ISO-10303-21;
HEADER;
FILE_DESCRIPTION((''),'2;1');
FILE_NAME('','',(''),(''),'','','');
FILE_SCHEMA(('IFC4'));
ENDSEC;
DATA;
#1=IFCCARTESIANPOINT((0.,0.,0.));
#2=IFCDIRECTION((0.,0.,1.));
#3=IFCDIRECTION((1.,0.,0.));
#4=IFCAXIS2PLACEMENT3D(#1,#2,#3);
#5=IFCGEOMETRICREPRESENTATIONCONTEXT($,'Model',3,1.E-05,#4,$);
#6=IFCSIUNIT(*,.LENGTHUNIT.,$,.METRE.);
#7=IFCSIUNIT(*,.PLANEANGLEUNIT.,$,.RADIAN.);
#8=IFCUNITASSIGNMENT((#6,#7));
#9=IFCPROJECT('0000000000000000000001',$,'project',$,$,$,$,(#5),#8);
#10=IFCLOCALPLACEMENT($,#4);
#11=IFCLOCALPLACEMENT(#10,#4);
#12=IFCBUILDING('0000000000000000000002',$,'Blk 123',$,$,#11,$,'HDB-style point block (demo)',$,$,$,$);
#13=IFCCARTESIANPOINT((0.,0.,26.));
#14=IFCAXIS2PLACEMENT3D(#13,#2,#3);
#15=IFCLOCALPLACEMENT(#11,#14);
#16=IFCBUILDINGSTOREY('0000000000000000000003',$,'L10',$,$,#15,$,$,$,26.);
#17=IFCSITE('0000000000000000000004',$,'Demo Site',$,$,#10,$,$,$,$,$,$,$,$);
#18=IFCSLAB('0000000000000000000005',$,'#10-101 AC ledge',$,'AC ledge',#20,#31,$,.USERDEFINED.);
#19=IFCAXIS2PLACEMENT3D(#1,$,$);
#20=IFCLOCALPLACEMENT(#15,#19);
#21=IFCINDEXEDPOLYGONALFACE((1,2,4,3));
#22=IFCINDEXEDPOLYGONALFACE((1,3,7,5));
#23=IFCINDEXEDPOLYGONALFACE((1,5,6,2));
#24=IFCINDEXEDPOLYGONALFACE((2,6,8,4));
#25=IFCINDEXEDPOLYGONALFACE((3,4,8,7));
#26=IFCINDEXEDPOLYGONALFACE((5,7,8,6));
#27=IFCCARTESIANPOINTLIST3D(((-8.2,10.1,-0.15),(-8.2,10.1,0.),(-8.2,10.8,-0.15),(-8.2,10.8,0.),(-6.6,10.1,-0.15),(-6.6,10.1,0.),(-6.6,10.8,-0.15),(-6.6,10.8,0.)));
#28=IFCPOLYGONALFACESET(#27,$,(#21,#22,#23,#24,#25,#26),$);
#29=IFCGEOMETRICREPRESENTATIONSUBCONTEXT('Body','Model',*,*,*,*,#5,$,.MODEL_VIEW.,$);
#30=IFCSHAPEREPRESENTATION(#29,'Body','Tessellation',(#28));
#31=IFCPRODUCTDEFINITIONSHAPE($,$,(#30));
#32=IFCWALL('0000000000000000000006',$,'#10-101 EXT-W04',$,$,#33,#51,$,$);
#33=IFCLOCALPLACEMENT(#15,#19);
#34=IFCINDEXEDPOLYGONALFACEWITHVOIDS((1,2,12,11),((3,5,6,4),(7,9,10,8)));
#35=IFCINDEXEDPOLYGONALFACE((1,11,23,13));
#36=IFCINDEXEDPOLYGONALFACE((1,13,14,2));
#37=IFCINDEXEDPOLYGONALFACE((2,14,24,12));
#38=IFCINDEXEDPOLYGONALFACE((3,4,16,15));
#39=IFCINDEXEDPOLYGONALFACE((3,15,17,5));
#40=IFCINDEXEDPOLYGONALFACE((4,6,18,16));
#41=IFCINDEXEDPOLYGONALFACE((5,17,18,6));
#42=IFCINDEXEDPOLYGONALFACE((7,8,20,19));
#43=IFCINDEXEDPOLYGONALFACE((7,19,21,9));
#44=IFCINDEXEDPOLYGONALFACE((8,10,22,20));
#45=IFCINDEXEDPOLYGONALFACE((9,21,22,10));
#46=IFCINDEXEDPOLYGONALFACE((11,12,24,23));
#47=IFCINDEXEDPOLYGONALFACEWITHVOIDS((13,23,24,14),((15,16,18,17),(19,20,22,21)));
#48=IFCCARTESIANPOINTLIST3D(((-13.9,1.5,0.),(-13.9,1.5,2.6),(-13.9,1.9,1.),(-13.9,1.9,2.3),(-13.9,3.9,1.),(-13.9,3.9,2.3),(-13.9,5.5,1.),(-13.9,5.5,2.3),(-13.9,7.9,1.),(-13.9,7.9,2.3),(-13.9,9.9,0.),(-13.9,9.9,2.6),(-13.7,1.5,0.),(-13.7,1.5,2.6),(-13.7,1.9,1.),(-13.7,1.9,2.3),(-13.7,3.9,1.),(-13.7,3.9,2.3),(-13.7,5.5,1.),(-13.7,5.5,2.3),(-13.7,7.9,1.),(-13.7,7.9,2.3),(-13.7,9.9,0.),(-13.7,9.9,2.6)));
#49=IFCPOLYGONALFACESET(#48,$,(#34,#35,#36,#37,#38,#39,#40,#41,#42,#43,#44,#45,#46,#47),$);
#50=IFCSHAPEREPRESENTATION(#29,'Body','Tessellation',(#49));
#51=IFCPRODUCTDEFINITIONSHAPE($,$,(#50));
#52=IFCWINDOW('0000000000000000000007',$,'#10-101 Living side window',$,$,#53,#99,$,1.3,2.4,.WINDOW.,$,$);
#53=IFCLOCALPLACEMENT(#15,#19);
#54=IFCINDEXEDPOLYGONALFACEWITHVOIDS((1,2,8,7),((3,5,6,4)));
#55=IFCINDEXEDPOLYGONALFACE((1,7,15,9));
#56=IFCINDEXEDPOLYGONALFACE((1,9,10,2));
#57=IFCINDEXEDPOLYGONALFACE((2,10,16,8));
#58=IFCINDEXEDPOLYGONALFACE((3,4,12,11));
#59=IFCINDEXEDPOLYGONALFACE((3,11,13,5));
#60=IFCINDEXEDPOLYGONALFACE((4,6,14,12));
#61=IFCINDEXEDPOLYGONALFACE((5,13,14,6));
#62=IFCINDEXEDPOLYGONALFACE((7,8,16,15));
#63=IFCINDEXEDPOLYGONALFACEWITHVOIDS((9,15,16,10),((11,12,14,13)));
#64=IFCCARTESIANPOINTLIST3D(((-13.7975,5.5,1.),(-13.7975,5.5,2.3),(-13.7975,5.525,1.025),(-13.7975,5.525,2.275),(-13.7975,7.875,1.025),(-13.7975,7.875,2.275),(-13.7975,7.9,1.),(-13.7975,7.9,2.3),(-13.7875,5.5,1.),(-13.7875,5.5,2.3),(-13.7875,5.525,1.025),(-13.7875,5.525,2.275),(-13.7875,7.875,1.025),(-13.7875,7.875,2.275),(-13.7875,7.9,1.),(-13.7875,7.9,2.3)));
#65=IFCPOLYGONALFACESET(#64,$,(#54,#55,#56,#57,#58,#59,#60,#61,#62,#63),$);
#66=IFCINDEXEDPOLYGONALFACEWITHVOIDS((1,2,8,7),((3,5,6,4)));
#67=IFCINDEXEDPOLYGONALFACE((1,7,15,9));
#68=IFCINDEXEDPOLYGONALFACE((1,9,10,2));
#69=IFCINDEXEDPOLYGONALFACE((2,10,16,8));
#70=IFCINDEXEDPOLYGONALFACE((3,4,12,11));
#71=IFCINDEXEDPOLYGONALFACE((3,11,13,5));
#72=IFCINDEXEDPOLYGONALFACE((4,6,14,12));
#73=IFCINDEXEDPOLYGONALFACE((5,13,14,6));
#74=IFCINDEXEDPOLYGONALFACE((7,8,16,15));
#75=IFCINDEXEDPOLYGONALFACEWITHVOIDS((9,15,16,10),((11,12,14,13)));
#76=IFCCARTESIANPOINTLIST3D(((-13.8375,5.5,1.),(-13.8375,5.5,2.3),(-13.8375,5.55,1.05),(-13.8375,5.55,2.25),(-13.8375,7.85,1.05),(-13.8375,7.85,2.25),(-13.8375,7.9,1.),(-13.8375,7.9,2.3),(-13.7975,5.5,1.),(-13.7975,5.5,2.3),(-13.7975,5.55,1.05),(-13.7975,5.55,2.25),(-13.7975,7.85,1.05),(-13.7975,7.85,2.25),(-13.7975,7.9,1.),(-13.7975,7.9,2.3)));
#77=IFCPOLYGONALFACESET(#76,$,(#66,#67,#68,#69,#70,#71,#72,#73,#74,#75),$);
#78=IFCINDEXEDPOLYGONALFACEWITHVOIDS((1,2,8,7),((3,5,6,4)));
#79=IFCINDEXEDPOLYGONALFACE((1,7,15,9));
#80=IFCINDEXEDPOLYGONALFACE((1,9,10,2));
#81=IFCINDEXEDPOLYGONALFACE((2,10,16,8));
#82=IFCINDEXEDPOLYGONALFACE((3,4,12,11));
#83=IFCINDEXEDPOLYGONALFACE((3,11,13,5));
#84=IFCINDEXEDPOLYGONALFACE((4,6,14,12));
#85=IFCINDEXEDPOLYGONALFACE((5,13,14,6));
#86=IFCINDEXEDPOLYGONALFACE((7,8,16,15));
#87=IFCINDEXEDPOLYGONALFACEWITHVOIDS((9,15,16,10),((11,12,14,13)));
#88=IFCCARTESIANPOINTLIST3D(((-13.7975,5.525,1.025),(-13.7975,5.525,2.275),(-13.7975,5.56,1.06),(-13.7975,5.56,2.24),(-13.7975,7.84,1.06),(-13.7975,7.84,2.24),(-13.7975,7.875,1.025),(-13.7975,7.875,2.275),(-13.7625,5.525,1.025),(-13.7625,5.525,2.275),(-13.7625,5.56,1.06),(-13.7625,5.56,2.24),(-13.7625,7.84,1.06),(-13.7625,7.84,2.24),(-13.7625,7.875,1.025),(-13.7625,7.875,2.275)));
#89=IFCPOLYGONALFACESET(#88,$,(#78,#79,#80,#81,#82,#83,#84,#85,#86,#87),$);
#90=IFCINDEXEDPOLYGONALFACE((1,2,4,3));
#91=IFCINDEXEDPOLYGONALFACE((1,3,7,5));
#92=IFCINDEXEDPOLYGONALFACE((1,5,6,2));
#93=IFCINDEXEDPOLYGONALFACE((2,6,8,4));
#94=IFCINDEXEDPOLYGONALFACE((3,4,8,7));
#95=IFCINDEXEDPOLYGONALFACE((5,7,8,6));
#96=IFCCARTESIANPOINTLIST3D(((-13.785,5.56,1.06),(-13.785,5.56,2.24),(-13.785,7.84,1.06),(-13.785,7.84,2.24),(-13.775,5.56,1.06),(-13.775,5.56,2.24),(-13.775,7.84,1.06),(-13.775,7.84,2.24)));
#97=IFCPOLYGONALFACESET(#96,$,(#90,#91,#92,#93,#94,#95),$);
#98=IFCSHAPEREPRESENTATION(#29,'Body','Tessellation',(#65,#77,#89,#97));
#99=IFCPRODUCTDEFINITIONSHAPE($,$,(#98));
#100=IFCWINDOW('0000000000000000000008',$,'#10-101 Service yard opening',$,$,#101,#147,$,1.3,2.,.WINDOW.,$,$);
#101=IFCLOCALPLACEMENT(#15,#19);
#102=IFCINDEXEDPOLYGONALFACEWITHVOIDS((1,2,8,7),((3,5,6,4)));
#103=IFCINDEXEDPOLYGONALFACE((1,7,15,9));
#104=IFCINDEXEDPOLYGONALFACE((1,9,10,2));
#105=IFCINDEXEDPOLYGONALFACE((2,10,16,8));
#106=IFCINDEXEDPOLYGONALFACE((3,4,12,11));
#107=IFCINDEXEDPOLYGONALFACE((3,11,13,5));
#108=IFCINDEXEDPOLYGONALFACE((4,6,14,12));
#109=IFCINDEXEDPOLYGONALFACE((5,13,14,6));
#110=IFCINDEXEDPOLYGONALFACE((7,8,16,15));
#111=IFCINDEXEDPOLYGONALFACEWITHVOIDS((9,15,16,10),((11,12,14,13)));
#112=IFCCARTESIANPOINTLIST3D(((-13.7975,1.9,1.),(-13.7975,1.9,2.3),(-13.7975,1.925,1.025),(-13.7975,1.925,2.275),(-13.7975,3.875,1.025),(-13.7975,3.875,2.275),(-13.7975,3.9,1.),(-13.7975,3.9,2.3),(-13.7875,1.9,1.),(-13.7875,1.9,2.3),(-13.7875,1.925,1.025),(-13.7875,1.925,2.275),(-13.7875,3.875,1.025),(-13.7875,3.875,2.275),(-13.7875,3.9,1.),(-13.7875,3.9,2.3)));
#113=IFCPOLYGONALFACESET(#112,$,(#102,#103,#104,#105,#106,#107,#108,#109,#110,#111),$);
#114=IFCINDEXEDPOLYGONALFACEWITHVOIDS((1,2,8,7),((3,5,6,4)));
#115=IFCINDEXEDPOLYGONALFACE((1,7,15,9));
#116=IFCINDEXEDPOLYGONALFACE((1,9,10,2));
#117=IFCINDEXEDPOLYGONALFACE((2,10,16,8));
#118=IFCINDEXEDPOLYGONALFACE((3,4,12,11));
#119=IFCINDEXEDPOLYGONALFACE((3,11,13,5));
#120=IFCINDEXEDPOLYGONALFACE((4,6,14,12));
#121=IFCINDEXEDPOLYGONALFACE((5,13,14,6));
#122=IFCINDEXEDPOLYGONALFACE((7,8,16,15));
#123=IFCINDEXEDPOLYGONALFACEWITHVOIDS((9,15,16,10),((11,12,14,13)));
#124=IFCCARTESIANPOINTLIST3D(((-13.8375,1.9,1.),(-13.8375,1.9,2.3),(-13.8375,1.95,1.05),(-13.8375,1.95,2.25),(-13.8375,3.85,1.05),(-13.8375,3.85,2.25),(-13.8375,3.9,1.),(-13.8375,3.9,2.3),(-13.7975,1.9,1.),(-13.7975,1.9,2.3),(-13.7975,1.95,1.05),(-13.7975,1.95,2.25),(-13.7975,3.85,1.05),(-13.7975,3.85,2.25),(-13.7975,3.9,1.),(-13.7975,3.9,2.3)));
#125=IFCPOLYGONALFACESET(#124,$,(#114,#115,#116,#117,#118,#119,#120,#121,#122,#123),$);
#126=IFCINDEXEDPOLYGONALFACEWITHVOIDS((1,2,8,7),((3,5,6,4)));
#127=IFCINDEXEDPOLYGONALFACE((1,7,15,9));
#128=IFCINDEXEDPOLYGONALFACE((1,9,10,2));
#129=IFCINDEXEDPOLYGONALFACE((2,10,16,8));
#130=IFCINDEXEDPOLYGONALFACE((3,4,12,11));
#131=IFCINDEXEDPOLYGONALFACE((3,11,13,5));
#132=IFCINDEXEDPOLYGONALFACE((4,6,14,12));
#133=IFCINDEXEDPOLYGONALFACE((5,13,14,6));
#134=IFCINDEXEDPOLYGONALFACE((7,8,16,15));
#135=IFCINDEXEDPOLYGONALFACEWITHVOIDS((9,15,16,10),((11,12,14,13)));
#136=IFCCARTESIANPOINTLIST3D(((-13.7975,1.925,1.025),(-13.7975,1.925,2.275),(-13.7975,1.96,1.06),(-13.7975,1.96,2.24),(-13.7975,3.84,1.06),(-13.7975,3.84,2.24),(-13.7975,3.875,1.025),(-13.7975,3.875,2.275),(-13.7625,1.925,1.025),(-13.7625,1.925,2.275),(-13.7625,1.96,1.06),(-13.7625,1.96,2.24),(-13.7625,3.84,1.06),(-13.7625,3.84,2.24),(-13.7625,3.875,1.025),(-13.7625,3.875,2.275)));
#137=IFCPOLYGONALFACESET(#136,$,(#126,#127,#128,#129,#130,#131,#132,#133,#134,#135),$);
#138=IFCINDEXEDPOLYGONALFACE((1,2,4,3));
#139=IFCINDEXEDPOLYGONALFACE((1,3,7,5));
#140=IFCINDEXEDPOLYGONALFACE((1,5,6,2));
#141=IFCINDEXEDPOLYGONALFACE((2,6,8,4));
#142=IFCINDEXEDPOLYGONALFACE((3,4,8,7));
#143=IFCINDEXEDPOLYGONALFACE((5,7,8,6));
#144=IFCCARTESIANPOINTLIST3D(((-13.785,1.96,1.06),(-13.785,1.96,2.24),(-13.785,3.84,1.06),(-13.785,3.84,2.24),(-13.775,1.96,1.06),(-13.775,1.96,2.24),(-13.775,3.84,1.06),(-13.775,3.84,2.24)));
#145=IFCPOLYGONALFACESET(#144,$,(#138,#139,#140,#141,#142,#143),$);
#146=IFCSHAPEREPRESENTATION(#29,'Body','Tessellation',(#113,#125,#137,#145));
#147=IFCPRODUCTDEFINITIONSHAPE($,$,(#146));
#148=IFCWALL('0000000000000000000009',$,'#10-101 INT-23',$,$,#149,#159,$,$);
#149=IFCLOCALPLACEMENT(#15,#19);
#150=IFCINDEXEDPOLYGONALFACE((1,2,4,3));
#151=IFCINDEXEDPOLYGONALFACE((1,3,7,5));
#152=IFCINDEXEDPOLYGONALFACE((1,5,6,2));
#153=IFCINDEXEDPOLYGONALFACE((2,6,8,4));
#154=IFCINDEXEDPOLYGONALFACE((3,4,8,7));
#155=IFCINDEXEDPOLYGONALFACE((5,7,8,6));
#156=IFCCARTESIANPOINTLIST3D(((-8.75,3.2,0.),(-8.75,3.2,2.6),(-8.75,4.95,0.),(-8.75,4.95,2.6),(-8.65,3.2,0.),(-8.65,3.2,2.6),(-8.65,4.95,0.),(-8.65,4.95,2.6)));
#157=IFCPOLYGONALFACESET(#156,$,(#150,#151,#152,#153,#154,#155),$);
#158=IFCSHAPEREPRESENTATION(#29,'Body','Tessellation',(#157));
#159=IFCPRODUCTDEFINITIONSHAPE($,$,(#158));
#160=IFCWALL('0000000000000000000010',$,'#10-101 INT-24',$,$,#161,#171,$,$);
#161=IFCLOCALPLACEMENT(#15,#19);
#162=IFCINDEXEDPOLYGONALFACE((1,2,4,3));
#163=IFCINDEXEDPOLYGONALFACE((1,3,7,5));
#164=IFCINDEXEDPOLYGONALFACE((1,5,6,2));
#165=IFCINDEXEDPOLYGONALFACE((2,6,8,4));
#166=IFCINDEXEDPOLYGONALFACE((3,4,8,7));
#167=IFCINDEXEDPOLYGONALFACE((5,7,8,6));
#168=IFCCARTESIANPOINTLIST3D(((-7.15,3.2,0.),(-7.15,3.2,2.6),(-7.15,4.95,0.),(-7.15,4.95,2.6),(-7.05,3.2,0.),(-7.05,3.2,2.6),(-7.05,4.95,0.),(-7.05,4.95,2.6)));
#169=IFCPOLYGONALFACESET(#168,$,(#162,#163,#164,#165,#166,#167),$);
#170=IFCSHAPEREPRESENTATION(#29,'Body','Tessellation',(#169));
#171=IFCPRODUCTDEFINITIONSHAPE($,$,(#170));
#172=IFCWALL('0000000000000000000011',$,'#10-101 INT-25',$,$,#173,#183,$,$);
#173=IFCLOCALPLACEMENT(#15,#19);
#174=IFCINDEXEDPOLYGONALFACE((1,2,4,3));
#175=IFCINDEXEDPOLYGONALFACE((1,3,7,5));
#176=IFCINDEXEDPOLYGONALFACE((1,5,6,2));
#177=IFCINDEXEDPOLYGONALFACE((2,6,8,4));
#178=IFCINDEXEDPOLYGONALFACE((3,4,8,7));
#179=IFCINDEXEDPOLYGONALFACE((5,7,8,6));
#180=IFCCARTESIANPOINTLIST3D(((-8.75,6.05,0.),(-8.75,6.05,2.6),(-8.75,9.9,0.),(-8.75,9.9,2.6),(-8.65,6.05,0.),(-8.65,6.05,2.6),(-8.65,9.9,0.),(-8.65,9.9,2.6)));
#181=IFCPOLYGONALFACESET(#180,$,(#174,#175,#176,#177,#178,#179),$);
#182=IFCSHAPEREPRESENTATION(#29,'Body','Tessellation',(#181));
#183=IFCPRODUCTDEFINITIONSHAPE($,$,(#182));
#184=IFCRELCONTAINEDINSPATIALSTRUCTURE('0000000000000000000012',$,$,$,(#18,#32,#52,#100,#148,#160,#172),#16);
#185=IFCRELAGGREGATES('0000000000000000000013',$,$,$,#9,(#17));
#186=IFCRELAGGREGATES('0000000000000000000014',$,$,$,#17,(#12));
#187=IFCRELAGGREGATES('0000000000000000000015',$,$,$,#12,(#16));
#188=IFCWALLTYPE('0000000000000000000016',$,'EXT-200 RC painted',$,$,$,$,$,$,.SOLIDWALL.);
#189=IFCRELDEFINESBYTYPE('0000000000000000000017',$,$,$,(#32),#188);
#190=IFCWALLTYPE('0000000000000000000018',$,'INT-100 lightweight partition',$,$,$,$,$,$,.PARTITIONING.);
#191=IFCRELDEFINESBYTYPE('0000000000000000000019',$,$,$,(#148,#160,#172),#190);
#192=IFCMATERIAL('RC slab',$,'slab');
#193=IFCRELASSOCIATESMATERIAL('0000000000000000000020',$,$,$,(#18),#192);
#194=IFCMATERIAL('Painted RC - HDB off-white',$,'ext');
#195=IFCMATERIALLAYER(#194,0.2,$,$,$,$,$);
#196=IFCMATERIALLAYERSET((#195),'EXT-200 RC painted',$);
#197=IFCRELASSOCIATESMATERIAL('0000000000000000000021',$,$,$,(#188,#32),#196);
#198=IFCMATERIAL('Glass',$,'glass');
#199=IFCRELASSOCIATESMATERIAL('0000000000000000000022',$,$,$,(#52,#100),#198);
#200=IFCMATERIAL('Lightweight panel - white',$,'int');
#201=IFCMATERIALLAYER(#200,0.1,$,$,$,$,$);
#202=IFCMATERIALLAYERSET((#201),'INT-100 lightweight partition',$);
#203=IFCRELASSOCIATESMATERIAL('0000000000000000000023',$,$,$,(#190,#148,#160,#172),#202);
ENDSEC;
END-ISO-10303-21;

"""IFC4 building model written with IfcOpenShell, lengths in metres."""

from ifc_helpers import new_model, si_unit, frame, origin, origin_with_axes, place, context, subcontext, project, spatial, polyline, line, indexed_curve, outline, extrude, material, layer, layer_set, layer_usage, type_object, element, fill, save


model = new_model("IFC4")

# Units and contexts
model_context = context("Model", 3, precision=1e-05, world=origin_with_axes())
body_context = subcontext(model_context, "Body", "Model", "MODEL_VIEW")
ifc_project = project(units=[si_unit("LENGTHUNIT", "METRE"), si_unit("PLANEANGLEUNIT", "RADIAN")], contexts=[model_context])

# Site, building, storey
site_placement = place(None, origin_with_axes())
site = spatial("IfcSite", under=ifc_project, at=site_placement, Name="Demo Site")
building_placement = place(site_placement, origin_with_axes())
building = spatial("IfcBuilding", under=site, at=building_placement, Name="Blk 123", LongName="HDB-style point block (demo)")
storey_placement = place(building_placement, frame((0.0, 0.0, 26.0), z_axis=(0.0, 0.0, 1.0), x_axis=(1.0, 0.0, 0.0)))
storey = spatial("IfcBuildingStorey", under=building, at=storey_placement, Name="L10", Elevation=26.0)

# Slab
ifc_material_1 = material(Name="RC slab", Category="slab")
slab_placement = place(storey_placement, frame((-7.4, 10.45, -0.15), z_axis=(0.0, 0.0, 1.0), x_axis=(1.0, 0.0, 0.0)))
element("IfcSlab", 1, at=slab_placement, inside=storey, material=ifc_material_1, Name="#10-101 AC ledge", ObjectType="AC ledge", PredefinedType="USERDEFINED", context=body_context, shape_type="SweptSolid", body=[
    extrude(outline(polyline([(-0.8, -0.35), (0.8, -0.35), (0.8, 0.35), (-0.8, 0.35), (-0.8, -0.35)])), origin(), (0.0, 0.0, 1.0), 0.15),
])

# Shared definitions
ifc_material_2 = material(Name="Painted RC - HDB off-white", Category="ext")
ifc_layer_1 = layer(ifc_material_2, 0.2)
ifc_layer_set_1 = layer_set([ifc_layer_1], Name="EXT-200 RC painted")
ifc_layer_usage_1 = layer_usage(ifc_layer_set_1, "AXIS2", "POSITIVE", 0.0)
wall_type_1 = type_object("IfcWallType", Name="EXT-200 RC painted", PredefinedType="SOLIDWALL", material=ifc_layer_set_1)
ifc_material_3 = material(Name="Glass", Category="glass")

# Wall, openings, windows
wall_1_placement = place(storey_placement, frame((-13.9, 9.9, 0.0), z_axis=(0.0, 0.0, 1.0), x_axis=(0.0, -1.0, 0.0)))
wall_1 = element("IfcWall", 2, at=wall_1_placement, inside=storey, type_object=wall_type_1, material=ifc_layer_usage_1, Name="#10-101 EXT-W04", context=body_context, shape_type="SweptSolid", body=[
    extrude(outline(indexed_curve([(0.0, 0.0), (0.0, 0.2), (8.4, 0.2), (8.4, 0.0), (0.0, 0.0)], self_intersect=False)), origin_with_axes(), (0.0, 0.0, 1.0), 2.6),
])
opening_1_placement = place(wall_1_placement, frame((2.0, -0.1, 1.0), z_axis=(0.0, 0.0, 1.0), x_axis=(1.0, 0.0, 0.0)))
opening_1 = element("IfcOpeningElement", 3, at=opening_1_placement, cuts=wall_1, context=body_context, shape_type="SweptSolid", body=[
    extrude(outline(indexed_curve([(0.0, 0.0), (0.0, 0.4), (2.4, 0.4), (2.4, 0.0), (0.0, 0.0)], self_intersect=False)), origin_with_axes(), (0.0, 0.0, 1.0), 1.3),
])
opening_2_placement = place(wall_1_placement, frame((6.0, -0.1, 1.0), z_axis=(0.0, 0.0, 1.0), x_axis=(1.0, 0.0, 0.0)))
opening_2 = element("IfcOpeningElement", 4, at=opening_2_placement, cuts=wall_1, context=body_context, shape_type="SweptSolid", body=[
    extrude(outline(indexed_curve([(0.0, 0.0), (0.0, 0.4), (2.0, 0.4), (2.0, 0.0), (0.0, 0.0)], self_intersect=False)), origin_with_axes(), (0.0, 0.0, 1.0), 1.3),
])
window_1_placement = place(opening_1_placement, frame((0.0, 0.1125, 0.0), z_axis=(0.0, 0.0, 1.0), x_axis=(1.0, 0.0, 0.0)))
window_1 = element("IfcWindow", 5, at=window_1_placement, inside=storey, material=ifc_material_3, Name="#10-101 Living side window", OverallHeight=1.3, OverallWidth=2.4, PredefinedType="WINDOW", context=body_context, shape_type="SweptSolid", body=[
    extrude(outline(indexed_curve([(0.0, 0.0), (2.4, 0.0), (2.4, 1.3), (0.0, 1.3)], segments=[line(1, 2, 3, 4, 1)]), holes=[indexed_curve([(0.025, 0.025), (2.375, 0.025), (2.375, 1.275), (0.025, 1.275)], segments=[line(1, 2, 3, 4, 1)])]), frame((0.0, 0.09, 0.0), z_axis=(0.0, -1.0, 0.0), x_axis=(1.0, 0.0, 0.0)), (0.0, 0.0, -1.0), 0.01),
    extrude(outline(indexed_curve([(0.0, 0.0), (2.4, 0.0), (2.4, 1.3), (0.0, 1.3)], segments=[line(1, 2, 3, 4, 1)]), holes=[indexed_curve([(0.05, 0.05), (2.35, 0.05), (2.35, 1.25), (0.05, 1.25)], segments=[line(1, 2, 3, 4, 1)])]), frame((0.0, 0.05, 0.0), z_axis=(0.0, -1.0, 0.0), x_axis=(1.0, 0.0, 0.0)), (0.0, 0.0, -1.0), 0.04),
    extrude(outline(indexed_curve([(0.0, 0.0), (2.35, 0.0), (2.35, 1.25), (0.0, 1.25)], segments=[line(1, 2, 3, 4, 1)]), holes=[indexed_curve([(0.035, 0.035), (2.315, 0.035), (2.315, 1.215), (0.035, 1.215)], segments=[line(1, 2, 3, 4, 1)])]), frame((0.025, 0.09, 0.025), z_axis=(0.0, -1.0, 0.0), x_axis=(1.0, 0.0, 0.0)), (0.0, 0.0, -1.0), 0.035),
    extrude(outline(indexed_curve([(0.035, 0.035), (2.315, 0.035), (2.315, 1.215), (0.035, 1.215)], segments=[line(1, 2, 3, 4, 1)])), frame((0.025, 0.1025, 0.025), z_axis=(0.0, -1.0, 0.0), x_axis=(1.0, 0.0, 0.0)), (0.0, 0.0, -1.0), 0.01),
])
fill(opening_1, window_1)
window_2_placement = place(opening_2_placement, frame((0.0, 0.1125, 0.0), z_axis=(0.0, 0.0, 1.0), x_axis=(1.0, 0.0, 0.0)))
window_2 = element("IfcWindow", 6, at=window_2_placement, inside=storey, material=ifc_material_3, Name="#10-101 Service yard opening", OverallHeight=1.3, OverallWidth=2.0, PredefinedType="WINDOW", context=body_context, shape_type="SweptSolid", body=[
    extrude(outline(indexed_curve([(0.0, 0.0), (2.0, 0.0), (2.0, 1.3), (0.0, 1.3)], segments=[line(1, 2, 3, 4, 1)]), holes=[indexed_curve([(0.025, 0.025), (1.975, 0.025), (1.975, 1.275), (0.025, 1.275)], segments=[line(1, 2, 3, 4, 1)])]), frame((0.0, 0.09, 0.0), z_axis=(0.0, -1.0, 0.0), x_axis=(1.0, 0.0, 0.0)), (0.0, 0.0, -1.0), 0.01),
    extrude(outline(indexed_curve([(0.0, 0.0), (2.0, 0.0), (2.0, 1.3), (0.0, 1.3)], segments=[line(1, 2, 3, 4, 1)]), holes=[indexed_curve([(0.05, 0.05), (1.95, 0.05), (1.95, 1.25), (0.05, 1.25)], segments=[line(1, 2, 3, 4, 1)])]), frame((0.0, 0.05, 0.0), z_axis=(0.0, -1.0, 0.0), x_axis=(1.0, 0.0, 0.0)), (0.0, 0.0, -1.0), 0.04),
    extrude(outline(indexed_curve([(0.0, 0.0), (1.95, 0.0), (1.95, 1.25), (0.0, 1.25)], segments=[line(1, 2, 3, 4, 1)]), holes=[indexed_curve([(0.035, 0.035), (1.915, 0.035), (1.915, 1.215), (0.035, 1.215)], segments=[line(1, 2, 3, 4, 1)])]), frame((0.025, 0.09, 0.025), z_axis=(0.0, -1.0, 0.0), x_axis=(1.0, 0.0, 0.0)), (0.0, 0.0, -1.0), 0.035),
    extrude(outline(indexed_curve([(0.035, 0.035), (1.915, 0.035), (1.915, 1.215), (0.035, 1.215)], segments=[line(1, 2, 3, 4, 1)])), frame((0.025, 0.1025, 0.025), z_axis=(0.0, -1.0, 0.0), x_axis=(1.0, 0.0, 0.0)), (0.0, 0.0, -1.0), 0.01),
])
fill(opening_2, window_2)

# Walls
ifc_material_4 = material(Name="Lightweight panel - white", Category="int")
ifc_layer_2 = layer(ifc_material_4, 0.1)
ifc_layer_set_2 = layer_set([ifc_layer_2], Name="INT-100 lightweight partition")
ifc_layer_usage_2 = layer_usage(ifc_layer_set_2, "AXIS2", "POSITIVE", -0.05)
wall_type_2 = type_object("IfcWallType", Name="INT-100 lightweight partition", PredefinedType="PARTITIONING", material=ifc_layer_set_2)
for number, where, z_axis, x_axis, name in (
    (7, (-8.7, 3.2, 0.0), (0.0, 0.0, 1.0), (0.0, 1.0, 0.0), "#10-101 INT-23"),
    (8, (-7.1, 3.2, 0.0), (0.0, 0.0, 1.0), (0.0, 1.0, 0.0), "#10-101 INT-24"),
):
    element("IfcWall", number, at=place(storey_placement, frame(where, z_axis=z_axis, x_axis=x_axis)), inside=storey, type_object=wall_type_2, material=ifc_layer_usage_2, Name=name, context=body_context, shape_type="SweptSolid", body=[
        extrude(outline(indexed_curve([(0.0, 0.0), (0.0, 0.1), (1.75, 0.1), (1.75, 0.0), (0.0, 0.0)], self_intersect=False)), frame((0.0, -0.05, 0.0), z_axis=(0.0, 0.0, 1.0), x_axis=(1.0, 0.0, 0.0)), (0.0, 0.0, 1.0), 2.6),
    ])
wall_2_placement = place(storey_placement, frame((-8.7, 6.05, 0.0), z_axis=(0.0, 0.0, 1.0), x_axis=(0.0, 1.0, 0.0)))
element("IfcWall", 9, at=wall_2_placement, inside=storey, type_object=wall_type_2, material=ifc_layer_usage_2, Name="#10-101 INT-25", context=body_context, shape_type="SweptSolid", body=[
    extrude(outline(indexed_curve([(0.0, 0.0), (0.0, 0.1), (3.85, 0.1), (3.85, 0.0), (0.0, 0.0)], self_intersect=False)), frame((0.0, -0.05, 0.0), z_axis=(0.0, 0.0, 1.0), x_axis=(1.0, 0.0, 0.0)), (0.0, 0.0, 1.0), 2.6),
])

save(model, "model.ifc")
